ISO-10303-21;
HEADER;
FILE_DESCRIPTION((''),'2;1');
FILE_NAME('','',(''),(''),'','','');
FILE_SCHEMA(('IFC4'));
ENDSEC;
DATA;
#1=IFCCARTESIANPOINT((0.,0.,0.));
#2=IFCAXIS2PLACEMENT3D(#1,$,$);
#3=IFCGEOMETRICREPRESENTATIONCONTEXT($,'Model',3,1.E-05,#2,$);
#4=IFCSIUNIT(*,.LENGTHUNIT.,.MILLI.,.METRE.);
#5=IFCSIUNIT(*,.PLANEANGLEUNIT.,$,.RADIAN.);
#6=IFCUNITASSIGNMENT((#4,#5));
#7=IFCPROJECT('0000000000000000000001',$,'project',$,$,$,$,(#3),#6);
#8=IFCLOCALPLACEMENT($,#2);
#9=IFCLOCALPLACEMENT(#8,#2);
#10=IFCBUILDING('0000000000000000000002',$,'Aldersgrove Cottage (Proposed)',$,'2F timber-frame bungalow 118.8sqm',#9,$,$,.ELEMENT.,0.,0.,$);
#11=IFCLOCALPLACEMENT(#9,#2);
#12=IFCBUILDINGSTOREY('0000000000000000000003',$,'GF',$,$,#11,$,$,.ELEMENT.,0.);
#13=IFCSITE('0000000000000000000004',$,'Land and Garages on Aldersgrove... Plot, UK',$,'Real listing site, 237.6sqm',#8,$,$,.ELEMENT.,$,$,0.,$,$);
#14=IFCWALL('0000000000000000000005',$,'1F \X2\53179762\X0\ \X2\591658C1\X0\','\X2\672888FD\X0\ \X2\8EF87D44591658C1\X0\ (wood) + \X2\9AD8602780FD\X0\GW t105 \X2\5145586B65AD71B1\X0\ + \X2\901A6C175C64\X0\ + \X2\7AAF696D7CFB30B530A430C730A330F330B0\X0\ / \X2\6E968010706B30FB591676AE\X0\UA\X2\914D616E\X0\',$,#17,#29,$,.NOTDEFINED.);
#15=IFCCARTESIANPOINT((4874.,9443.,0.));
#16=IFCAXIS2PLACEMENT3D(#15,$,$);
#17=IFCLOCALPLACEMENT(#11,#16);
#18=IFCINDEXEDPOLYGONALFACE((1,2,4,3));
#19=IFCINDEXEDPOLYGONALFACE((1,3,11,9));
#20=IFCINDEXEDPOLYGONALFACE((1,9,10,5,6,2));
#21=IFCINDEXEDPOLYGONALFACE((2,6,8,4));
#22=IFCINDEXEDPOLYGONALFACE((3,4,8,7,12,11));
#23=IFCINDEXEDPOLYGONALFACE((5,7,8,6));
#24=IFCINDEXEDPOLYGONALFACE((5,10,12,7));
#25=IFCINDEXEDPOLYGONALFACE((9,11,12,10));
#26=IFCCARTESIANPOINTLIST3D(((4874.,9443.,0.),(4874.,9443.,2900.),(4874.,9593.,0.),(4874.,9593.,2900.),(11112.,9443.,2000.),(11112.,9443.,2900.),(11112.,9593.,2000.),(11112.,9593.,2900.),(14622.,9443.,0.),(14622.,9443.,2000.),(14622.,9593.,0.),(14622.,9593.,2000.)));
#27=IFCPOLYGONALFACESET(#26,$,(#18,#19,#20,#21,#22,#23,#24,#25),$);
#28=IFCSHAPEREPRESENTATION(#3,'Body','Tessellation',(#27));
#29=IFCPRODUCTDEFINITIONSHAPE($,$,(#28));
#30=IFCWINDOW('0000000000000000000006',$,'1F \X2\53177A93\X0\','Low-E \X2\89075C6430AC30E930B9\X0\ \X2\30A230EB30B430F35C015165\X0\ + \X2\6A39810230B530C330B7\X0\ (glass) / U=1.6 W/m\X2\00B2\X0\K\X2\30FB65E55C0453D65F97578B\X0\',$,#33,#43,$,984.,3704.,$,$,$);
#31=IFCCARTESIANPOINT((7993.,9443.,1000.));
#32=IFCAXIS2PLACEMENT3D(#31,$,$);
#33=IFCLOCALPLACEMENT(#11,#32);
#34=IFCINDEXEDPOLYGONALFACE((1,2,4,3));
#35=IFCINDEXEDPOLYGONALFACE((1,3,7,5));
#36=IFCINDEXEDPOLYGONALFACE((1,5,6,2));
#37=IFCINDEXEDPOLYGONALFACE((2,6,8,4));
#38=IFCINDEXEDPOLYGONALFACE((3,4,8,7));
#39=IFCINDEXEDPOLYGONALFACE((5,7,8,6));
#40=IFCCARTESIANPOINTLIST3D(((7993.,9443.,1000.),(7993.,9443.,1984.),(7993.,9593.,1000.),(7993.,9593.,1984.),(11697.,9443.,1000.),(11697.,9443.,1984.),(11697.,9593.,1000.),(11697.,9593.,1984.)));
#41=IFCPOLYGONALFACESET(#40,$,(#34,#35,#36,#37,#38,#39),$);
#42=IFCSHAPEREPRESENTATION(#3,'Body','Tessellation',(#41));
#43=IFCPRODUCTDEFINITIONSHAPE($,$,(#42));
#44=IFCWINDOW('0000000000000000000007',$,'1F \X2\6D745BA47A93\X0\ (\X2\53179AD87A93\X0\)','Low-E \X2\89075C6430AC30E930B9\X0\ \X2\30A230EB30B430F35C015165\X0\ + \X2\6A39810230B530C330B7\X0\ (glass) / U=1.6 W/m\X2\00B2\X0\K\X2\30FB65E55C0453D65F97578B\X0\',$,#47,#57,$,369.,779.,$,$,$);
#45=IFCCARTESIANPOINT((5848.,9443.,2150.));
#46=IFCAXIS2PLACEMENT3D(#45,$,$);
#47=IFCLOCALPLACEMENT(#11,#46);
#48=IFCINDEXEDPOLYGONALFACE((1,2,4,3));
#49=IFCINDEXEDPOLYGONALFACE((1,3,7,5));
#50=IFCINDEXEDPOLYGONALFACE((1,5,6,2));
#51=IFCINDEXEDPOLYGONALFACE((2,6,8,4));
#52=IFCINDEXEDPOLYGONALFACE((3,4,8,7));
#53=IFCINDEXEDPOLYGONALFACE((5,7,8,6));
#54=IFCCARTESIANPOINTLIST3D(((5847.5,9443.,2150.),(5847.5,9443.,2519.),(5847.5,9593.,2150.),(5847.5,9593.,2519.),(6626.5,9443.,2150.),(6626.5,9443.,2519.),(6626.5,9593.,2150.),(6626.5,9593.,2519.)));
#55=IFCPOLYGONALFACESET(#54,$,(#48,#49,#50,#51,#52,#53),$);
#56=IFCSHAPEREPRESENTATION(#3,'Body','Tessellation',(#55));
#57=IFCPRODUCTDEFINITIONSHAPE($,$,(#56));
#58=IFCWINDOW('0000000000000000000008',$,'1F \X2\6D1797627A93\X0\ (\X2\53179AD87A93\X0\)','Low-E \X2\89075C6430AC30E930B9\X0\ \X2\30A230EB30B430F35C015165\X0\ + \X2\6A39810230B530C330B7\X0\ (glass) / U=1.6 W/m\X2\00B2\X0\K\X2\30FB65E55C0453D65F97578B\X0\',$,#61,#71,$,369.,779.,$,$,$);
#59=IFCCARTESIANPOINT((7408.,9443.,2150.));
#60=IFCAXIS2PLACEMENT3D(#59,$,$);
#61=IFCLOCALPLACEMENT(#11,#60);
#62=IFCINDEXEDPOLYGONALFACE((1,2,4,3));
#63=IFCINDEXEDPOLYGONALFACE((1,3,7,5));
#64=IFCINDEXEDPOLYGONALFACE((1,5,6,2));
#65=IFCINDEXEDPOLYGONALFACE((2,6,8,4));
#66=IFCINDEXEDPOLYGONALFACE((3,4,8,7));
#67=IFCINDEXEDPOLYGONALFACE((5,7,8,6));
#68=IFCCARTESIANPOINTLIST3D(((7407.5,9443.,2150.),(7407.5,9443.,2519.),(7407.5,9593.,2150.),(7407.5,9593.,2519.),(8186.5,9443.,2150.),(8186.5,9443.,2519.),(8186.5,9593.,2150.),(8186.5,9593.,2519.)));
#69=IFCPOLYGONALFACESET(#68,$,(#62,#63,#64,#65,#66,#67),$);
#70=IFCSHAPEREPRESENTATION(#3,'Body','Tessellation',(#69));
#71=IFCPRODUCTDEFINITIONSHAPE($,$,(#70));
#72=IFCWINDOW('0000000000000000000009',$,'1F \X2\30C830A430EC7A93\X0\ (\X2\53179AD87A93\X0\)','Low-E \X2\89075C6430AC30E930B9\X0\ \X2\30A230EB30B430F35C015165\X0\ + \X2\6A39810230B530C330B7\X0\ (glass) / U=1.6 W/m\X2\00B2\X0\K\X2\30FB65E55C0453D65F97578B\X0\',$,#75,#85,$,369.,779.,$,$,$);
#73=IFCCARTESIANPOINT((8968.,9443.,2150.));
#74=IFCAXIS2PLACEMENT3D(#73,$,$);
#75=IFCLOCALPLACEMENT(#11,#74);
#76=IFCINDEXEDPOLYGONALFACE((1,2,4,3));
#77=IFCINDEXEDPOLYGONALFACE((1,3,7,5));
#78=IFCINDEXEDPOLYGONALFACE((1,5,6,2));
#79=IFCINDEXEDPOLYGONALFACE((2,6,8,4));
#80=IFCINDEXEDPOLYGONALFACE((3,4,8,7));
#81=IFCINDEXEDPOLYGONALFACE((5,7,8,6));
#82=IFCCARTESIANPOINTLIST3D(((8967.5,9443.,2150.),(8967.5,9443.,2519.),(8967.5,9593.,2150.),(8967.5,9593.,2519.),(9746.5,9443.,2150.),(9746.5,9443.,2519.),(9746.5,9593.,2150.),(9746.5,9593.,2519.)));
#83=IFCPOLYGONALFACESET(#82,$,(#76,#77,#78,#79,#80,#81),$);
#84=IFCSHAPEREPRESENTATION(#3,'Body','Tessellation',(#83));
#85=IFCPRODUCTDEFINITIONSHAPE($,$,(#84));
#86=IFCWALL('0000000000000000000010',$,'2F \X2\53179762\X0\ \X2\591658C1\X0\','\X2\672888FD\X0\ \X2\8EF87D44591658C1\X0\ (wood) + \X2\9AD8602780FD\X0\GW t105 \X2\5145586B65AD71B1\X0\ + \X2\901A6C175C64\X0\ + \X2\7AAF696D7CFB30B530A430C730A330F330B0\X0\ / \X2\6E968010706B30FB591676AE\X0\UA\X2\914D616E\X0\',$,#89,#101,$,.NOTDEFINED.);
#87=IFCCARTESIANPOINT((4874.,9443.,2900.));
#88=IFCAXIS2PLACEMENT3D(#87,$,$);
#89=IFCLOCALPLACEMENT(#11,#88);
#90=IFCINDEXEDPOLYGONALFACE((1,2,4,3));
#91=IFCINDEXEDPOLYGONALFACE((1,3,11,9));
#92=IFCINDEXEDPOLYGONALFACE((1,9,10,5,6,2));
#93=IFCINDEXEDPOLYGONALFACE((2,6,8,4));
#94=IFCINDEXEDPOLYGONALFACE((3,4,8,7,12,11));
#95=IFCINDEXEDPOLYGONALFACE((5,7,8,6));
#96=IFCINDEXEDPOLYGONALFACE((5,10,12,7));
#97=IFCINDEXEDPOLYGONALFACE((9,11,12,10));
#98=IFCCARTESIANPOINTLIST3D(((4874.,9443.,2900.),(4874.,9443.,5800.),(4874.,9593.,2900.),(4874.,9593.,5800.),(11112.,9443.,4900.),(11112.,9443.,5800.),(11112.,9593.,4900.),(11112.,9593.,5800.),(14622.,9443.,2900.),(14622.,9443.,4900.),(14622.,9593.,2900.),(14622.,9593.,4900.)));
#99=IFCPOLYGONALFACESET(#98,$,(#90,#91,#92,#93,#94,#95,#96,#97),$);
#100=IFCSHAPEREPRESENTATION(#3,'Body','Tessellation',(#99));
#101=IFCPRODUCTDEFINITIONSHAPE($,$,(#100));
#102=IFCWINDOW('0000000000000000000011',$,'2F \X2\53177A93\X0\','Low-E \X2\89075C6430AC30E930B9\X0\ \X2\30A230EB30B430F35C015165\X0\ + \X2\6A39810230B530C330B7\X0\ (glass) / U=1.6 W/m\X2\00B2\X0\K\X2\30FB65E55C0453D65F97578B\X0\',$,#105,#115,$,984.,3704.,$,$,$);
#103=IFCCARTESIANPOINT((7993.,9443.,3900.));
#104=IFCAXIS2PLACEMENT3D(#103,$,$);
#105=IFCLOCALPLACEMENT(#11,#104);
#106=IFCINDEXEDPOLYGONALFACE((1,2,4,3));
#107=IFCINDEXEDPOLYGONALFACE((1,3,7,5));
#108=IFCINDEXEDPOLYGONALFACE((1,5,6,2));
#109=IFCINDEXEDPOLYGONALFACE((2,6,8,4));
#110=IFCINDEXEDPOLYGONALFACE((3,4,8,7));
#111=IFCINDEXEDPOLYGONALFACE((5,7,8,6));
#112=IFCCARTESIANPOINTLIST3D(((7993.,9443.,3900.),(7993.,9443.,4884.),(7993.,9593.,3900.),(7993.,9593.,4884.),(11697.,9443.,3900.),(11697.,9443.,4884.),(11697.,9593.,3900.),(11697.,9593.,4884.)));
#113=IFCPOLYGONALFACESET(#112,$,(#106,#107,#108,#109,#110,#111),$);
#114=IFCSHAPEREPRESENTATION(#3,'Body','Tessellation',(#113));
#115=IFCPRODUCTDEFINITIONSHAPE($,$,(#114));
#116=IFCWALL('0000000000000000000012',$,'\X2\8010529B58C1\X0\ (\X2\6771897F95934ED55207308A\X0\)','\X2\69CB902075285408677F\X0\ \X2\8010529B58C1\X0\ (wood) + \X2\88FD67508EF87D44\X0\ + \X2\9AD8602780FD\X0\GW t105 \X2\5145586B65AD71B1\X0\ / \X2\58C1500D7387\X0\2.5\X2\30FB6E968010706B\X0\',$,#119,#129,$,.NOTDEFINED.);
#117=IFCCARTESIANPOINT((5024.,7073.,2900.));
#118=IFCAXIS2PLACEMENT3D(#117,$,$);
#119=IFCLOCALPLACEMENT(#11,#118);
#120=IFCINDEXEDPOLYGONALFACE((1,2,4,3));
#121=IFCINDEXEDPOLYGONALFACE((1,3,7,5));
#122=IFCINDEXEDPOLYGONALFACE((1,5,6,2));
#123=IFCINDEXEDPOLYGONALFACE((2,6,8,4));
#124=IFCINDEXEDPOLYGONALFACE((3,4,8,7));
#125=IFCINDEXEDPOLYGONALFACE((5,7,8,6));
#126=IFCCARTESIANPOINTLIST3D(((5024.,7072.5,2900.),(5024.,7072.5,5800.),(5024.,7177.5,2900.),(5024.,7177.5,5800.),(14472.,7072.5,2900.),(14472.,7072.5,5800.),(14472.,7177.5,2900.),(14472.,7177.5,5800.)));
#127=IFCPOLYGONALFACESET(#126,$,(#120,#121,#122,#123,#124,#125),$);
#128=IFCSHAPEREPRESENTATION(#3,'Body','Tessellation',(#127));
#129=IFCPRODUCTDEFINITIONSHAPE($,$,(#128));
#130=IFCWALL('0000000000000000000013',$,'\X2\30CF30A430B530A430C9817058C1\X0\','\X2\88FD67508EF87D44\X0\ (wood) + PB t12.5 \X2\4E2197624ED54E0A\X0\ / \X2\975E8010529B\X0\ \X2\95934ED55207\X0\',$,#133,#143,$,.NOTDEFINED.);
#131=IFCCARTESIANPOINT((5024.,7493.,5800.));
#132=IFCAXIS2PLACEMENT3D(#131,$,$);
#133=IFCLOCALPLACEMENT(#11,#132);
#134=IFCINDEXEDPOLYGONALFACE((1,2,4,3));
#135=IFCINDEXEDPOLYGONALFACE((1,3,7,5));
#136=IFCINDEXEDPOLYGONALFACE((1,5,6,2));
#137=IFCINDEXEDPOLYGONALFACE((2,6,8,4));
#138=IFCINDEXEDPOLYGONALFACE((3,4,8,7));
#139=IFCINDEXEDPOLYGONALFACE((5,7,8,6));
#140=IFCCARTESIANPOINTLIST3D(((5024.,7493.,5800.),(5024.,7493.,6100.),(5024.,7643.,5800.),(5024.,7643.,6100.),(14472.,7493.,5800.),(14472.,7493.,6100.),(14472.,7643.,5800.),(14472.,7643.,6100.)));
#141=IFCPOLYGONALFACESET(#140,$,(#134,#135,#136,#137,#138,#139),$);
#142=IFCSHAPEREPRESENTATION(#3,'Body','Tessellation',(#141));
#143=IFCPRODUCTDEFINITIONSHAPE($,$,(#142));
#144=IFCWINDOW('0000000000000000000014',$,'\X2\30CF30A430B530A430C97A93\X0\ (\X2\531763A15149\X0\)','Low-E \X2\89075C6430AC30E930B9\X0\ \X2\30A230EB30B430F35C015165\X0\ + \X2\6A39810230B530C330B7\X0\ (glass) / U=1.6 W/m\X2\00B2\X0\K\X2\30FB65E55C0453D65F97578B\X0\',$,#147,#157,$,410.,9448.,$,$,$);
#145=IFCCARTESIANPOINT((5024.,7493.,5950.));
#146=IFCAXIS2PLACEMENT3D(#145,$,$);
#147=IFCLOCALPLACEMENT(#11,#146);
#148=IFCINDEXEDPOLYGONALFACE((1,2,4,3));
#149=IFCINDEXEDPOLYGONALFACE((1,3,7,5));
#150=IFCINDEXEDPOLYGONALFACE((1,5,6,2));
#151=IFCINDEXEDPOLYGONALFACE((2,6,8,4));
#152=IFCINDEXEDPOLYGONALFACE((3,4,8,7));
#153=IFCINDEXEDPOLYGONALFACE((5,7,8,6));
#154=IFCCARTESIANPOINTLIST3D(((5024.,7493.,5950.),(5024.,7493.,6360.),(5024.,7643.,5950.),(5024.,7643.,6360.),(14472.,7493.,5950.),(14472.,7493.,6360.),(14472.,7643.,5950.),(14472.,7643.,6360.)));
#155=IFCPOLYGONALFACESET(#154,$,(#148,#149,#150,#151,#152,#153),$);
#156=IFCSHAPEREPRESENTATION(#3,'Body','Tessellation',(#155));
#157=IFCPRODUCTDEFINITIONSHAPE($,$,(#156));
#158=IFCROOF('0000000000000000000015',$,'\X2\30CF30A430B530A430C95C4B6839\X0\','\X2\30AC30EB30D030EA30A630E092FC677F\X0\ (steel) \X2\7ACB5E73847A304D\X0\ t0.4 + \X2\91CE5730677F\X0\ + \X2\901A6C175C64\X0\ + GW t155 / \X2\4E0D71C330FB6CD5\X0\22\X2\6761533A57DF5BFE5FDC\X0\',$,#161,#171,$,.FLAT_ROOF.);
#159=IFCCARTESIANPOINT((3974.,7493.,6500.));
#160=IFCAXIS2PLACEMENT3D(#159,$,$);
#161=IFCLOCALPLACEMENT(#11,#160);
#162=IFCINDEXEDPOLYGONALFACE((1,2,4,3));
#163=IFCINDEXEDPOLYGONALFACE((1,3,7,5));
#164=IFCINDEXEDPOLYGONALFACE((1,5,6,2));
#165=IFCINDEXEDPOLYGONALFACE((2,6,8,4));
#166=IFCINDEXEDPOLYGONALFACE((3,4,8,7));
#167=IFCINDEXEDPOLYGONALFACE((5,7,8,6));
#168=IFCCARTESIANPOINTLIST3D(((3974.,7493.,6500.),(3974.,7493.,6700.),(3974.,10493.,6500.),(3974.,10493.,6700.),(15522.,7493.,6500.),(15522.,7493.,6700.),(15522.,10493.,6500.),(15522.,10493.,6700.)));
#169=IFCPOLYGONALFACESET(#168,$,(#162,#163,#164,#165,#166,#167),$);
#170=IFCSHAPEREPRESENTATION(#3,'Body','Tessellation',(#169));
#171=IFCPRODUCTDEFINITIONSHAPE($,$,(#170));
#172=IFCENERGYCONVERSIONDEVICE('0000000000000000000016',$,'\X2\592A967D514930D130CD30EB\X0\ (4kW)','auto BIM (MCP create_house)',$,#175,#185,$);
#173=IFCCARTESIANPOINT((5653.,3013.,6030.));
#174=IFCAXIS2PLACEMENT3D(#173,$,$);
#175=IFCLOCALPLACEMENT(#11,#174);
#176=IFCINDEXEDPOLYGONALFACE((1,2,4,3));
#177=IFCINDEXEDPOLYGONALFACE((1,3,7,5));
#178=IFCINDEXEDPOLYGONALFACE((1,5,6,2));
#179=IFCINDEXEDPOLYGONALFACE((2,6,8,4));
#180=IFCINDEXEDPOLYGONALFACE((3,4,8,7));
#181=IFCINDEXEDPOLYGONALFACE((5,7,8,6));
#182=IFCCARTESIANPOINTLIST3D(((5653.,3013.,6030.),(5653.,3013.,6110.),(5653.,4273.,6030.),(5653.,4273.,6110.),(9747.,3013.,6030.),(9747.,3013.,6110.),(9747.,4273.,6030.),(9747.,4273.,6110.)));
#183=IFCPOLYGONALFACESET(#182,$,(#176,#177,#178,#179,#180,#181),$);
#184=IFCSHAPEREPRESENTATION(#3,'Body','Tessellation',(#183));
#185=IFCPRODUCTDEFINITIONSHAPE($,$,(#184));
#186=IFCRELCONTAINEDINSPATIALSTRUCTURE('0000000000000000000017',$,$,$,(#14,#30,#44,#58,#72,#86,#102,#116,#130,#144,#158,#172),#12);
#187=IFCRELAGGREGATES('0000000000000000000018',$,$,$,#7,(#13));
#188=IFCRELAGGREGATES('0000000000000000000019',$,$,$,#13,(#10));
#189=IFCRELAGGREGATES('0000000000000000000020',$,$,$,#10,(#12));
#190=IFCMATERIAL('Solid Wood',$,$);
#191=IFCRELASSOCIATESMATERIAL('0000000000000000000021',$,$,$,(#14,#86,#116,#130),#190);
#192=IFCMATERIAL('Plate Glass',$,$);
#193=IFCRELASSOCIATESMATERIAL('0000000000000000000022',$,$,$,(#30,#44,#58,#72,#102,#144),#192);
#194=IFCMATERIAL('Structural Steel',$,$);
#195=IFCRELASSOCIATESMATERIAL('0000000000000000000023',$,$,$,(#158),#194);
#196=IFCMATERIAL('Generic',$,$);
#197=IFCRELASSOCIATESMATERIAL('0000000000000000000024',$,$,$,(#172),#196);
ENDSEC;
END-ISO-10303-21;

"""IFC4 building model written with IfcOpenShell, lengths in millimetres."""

from ifc_helpers import new_model, si_unit, frame, frame_2d, origin, place, context, project, spatial, rectangle, extrude, material, element, fill, save


model = new_model("IFC4")

# Units and contexts
model_context = context("Model", 3, precision=1e-05, world=origin())
ifc_project = project(units=[si_unit("LENGTHUNIT", "METRE", prefix="MILLI"), si_unit("PLANEANGLEUNIT", "RADIAN")], contexts=[model_context])

# Site, building, storey
site_placement = place(None, origin())
site = spatial("IfcSite", under=ifc_project, at=site_placement, Name="Land and Garages on Aldersgrove... Plot, UK", ObjectType="Real listing site, 237.6sqm", CompositionType="ELEMENT", RefElevation=0.0)
building_placement = place(site_placement, origin())
building = spatial("IfcBuilding", under=site, at=building_placement, Name="Aldersgrove Cottage (Proposed)", ObjectType="2F timber-frame bungalow 118.8sqm", CompositionType="ELEMENT", ElevationOfRefHeight=0.0, ElevationOfTerrain=0.0)
storey_placement = place(building_placement, origin())
storey = spatial("IfcBuildingStorey", under=building, at=storey_placement, Name="GF", CompositionType="ELEMENT", Elevation=0.0)

# Wall, openings, windows
ifc_material_1 = material(Name="Solid Wood")
wall_1_placement = place(storey_placement, frame((4874.0, 9443.0, 0.0)))
wall_1 = element("IfcWall", 1, at=wall_1_placement, inside=storey, material=ifc_material_1, Name="1F 北面 外壁", Description="木製 軸組外壁 (wood) + 高性能GW t105 充填断熱 + 通気層 + 窯業系サイディング / 準耐火・外皮UA配慮", PredefinedType="NOTDEFINED", context=model_context, shape_type="SweptSolid", body=[
    extrude(rectangle(XDim=9748.0, YDim=150.0, at=frame_2d((4874.0, 75.0))), frame((4874.0, 9443.0, 0.0)), (0.0, 0.0, 1.0), 2900.0),
])
opening_1_placement = place(storey_placement, frame((7993.0, 9443.0, 1000.0)))
opening_1 = element("IfcOpeningElement", 2, at=opening_1_placement, cuts=wall_1, PredefinedType="NOTDEFINED", context=model_context, shape_type="SweptSolid", body=[
    extrude(rectangle(XDim=3704.0, YDim=150.0, at=frame_2d((1852.0, 75.0))), frame((7993.0, 9443.0, 1000.0)), (0.0, 0.0, 1.0), 984.0),
])
opening_2_placement = place(storey_placement, frame((5848.0, 9443.0, 2150.0)))
opening_2 = element("IfcOpeningElement", 3, at=opening_2_placement, cuts=wall_1, PredefinedType="NOTDEFINED", context=model_context, shape_type="SweptSolid", body=[
    extrude(rectangle(XDim=779.0, YDim=150.0, at=frame_2d((389.0, 75.0))), frame((5848.0, 9443.0, 2150.0)), (0.0, 0.0, 1.0), 369.0),
])
opening_3_placement = place(storey_placement, frame((7408.0, 9443.0, 2150.0)))
opening_3 = element("IfcOpeningElement", 4, at=opening_3_placement, cuts=wall_1, PredefinedType="NOTDEFINED", context=model_context, shape_type="SweptSolid", body=[
    extrude(rectangle(XDim=779.0, YDim=150.0, at=frame_2d((389.0, 75.0))), frame((7408.0, 9443.0, 2150.0)), (0.0, 0.0, 1.0), 369.0),
])
opening_4_placement = place(storey_placement, frame((8968.0, 9443.0, 2150.0)))
opening_4 = element("IfcOpeningElement", 5, at=opening_4_placement, cuts=wall_1, PredefinedType="NOTDEFINED", context=model_context, shape_type="SweptSolid", body=[
    extrude(rectangle(XDim=779.0, YDim=150.0, at=frame_2d((389.0, 75.0))), frame((8968.0, 9443.0, 2150.0)), (0.0, 0.0, 1.0), 369.0),
])
ifc_material_2 = material(Name="Plate Glass")
window_1_placement = place(storey_placement, frame((7993.0, 9443.0, 1000.0)))
window_1 = element("IfcWindow", 6, at=window_1_placement, inside=storey, material=ifc_material_2, Name="1F 北窓", Description="Low-E 複層ガラス アルゴン封入 + 樹脂サッシ (glass) / U=1.6 W/m²K・日射取得型", OverallHeight=984.0, OverallWidth=3704.0, context=model_context, shape_type="SweptSolid", body=[
    extrude(rectangle(XDim=3704.0, YDim=150.0, at=frame_2d((1852.0, 75.0))), frame((7993.0, 9443.0, 1000.0)), (0.0, 0.0, 1.0), 984.0),
])
fill(opening_1, window_1)
window_2_placement = place(storey_placement, frame((5848.0, 9443.0, 2150.0)))
window_2 = element("IfcWindow", 7, at=window_2_placement, inside=storey, material=ifc_material_2, Name="1F 浴室窓 (北高窓)", Description="Low-E 複層ガラス アルゴン封入 + 樹脂サッシ (glass) / U=1.6 W/m²K・日射取得型", OverallHeight=369.0, OverallWidth=779.0, context=model_context, shape_type="SweptSolid", body=[
    extrude(rectangle(XDim=779.0, YDim=150.0, at=frame_2d((389.0, 75.0))), frame((5848.0, 9443.0, 2150.0)), (0.0, 0.0, 1.0), 369.0),
])
fill(opening_2, window_2)
window_3_placement = place(storey_placement, frame((7408.0, 9443.0, 2150.0)))
window_3 = element("IfcWindow", 8, at=window_3_placement, inside=storey, material=ifc_material_2, Name="1F 洗面窓 (北高窓)", Description="Low-E 複層ガラス アルゴン封入 + 樹脂サッシ (glass) / U=1.6 W/m²K・日射取得型", OverallHeight=369.0, OverallWidth=779.0, context=model_context, shape_type="SweptSolid", body=[
    extrude(rectangle(XDim=779.0, YDim=150.0, at=frame_2d((389.0, 75.0))), frame((7408.0, 9443.0, 2150.0)), (0.0, 0.0, 1.0), 369.0),
])
fill(opening_3, window_3)
window_4_placement = place(storey_placement, frame((8968.0, 9443.0, 2150.0)))
window_4 = element("IfcWindow", 9, at=window_4_placement, inside=storey, material=ifc_material_2, Name="1F トイレ窓 (北高窓)", Description="Low-E 複層ガラス アルゴン封入 + 樹脂サッシ (glass) / U=1.6 W/m²K・日射取得型", OverallHeight=369.0, OverallWidth=779.0, context=model_context, shape_type="SweptSolid", body=[
    extrude(rectangle(XDim=779.0, YDim=150.0, at=frame_2d((389.0, 75.0))), frame((8968.0, 9443.0, 2150.0)), (0.0, 0.0, 1.0), 369.0),
])
fill(opening_4, window_4)

# Wall, opening, window
wall_2_placement = place(storey_placement, frame((4874.0, 9443.0, 2900.0)))
wall_2 = element("IfcWall", 10, at=wall_2_placement, inside=storey, material=ifc_material_1, Name="2F 北面 外壁", Description="木製 軸組外壁 (wood) + 高性能GW t105 充填断熱 + 通気層 + 窯業系サイディング / 準耐火・外皮UA配慮", PredefinedType="NOTDEFINED", context=model_context, shape_type="SweptSolid", body=[
    extrude(rectangle(XDim=9748.0, YDim=150.0, at=frame_2d((4874.0, 75.0))), frame((4874.0, 9443.0, 2900.0)), (0.0, 0.0, 1.0), 2900.0),
])
opening_5_placement = place(storey_placement, frame((7993.0, 9443.0, 3900.0)))
opening_5 = element("IfcOpeningElement", 11, at=opening_5_placement, cuts=wall_2, PredefinedType="NOTDEFINED", context=model_context, shape_type="SweptSolid", body=[
    extrude(rectangle(XDim=3704.0, YDim=150.0, at=frame_2d((1852.0, 75.0))), frame((7993.0, 9443.0, 3900.0)), (0.0, 0.0, 1.0), 984.0),
])
window_5_placement = place(storey_placement, frame((7993.0, 9443.0, 3900.0)))
window_5 = element("IfcWindow", 12, at=window_5_placement, inside=storey, material=ifc_material_2, Name="2F 北窓", Description="Low-E 複層ガラス アルゴン封入 + 樹脂サッシ (glass) / U=1.6 W/m²K・日射取得型", OverallHeight=984.0, OverallWidth=3704.0, context=model_context, shape_type="SweptSolid", body=[
    extrude(rectangle(XDim=3704.0, YDim=150.0, at=frame_2d((1852.0, 75.0))), frame((7993.0, 9443.0, 3900.0)), (0.0, 0.0, 1.0), 984.0),
])
fill(opening_5, window_5)

# Wall
wall_3_placement = place(storey_placement, frame((5024.0, 7073.0, 2900.0)))
element("IfcWall", 13, at=wall_3_placement, inside=storey, material=ifc_material_1, Name="耐力壁 (東西間仕切り)", Description="構造用合板 耐力壁 (wood) + 製材軸組 + 高性能GW t105 充填断熱 / 壁倍率2.5・準耐火", PredefinedType="NOTDEFINED", context=model_context, shape_type="SweptSolid", body=[
    extrude(rectangle(XDim=9448.0, YDim=105.0, at=frame_2d((4724.0, 52.0))), frame((5024.0, 7073.0, 2900.0)), (0.0, 0.0, 1.0), 2900.0),
])

# Wall, opening, window
wall_4_placement = place(storey_placement, frame((5024.0, 7493.0, 5800.0)))
wall_4 = element("IfcWall", 14, at=wall_4_placement, inside=storey, material=ifc_material_1, Name="ハイサイド腰壁", Description="製材軸組 (wood) + PB t12.5 両面仕上 / 非耐力 間仕切", PredefinedType="NOTDEFINED", context=model_context, shape_type="SweptSolid", body=[
    extrude(rectangle(XDim=9448.0, YDim=150.0, at=frame_2d((4724.0, 75.0))), frame((5024.0, 7493.0, 5800.0)), (0.0, 0.0, 1.0), 700.0),
])
opening_6_placement = place(storey_placement, frame((5024.0, 7493.0, 5950.0)))
opening_6 = element("IfcOpeningElement", 15, at=opening_6_placement, cuts=wall_4, PredefinedType="NOTDEFINED", context=model_context, shape_type="SweptSolid", body=[
    extrude(rectangle(XDim=9448.0, YDim=150.0, at=frame_2d((4724.0, 75.0))), frame((5024.0, 7493.0, 5950.0)), (0.0, 0.0, 1.0), 410.0),
])
window_6_placement = place(storey_placement, frame((5024.0, 7493.0, 5950.0)))
window_6 = element("IfcWindow", 16, at=window_6_placement, inside=storey, material=ifc_material_2, Name="ハイサイド窓 (北採光)", Description="Low-E 複層ガラス アルゴン封入 + 樹脂サッシ (glass) / U=1.6 W/m²K・日射取得型", OverallHeight=410.0, OverallWidth=9448.0, context=model_context, shape_type="SweptSolid", body=[
    extrude(rectangle(XDim=9448.0, YDim=150.0, at=frame_2d((4724.0, 75.0))), frame((5024.0, 7493.0, 5950.0)), (0.0, 0.0, 1.0), 410.0),
])
fill(opening_6, window_6)

# Roof
ifc_material_3 = material(Name="Structural Steel")
roof_placement = place(storey_placement, frame((3974.0, 7493.0, 6500.0)))
element("IfcRoof", 17, at=roof_placement, inside=storey, material=ifc_material_3, Name="ハイサイド屋根", Description="ガルバリウム鋼板 (steel) 立平葺き t0.4 + 野地板 + 通気層 + GW t155 / 不燃・法22条区域対応", PredefinedType="FLAT_ROOF", context=model_context, shape_type="SweptSolid", body=[
    extrude(rectangle(XDim=11548.0, YDim=3000.0, at=frame_2d((5774.0, 1500.0))), frame((3974.0, 7493.0, 6500.0)), (0.0, 0.0, 1.0), 200.0),
])

# Energy conversion device
ifc_material_4 = material(Name="Generic")
energy_conversion_device_placement = place(storey_placement, frame((5653.0, 3013.0, 6030.0)))
element("IfcEnergyConversionDevice", 18, at=energy_conversion_device_placement, inside=storey, material=ifc_material_4, Name="太陽光パネル (4kW)", Description="auto BIM (MCP create_house)", context=model_context, shape_type="SweptSolid", body=[
    extrude(rectangle(XDim=4094.0, YDim=1260.0, at=frame_2d((2047.0, 630.0))), frame((5653.0, 3013.0, 6030.0)), (0.0, 0.0, 1.0), 80.0),
])

save(model, "model.ifc")
